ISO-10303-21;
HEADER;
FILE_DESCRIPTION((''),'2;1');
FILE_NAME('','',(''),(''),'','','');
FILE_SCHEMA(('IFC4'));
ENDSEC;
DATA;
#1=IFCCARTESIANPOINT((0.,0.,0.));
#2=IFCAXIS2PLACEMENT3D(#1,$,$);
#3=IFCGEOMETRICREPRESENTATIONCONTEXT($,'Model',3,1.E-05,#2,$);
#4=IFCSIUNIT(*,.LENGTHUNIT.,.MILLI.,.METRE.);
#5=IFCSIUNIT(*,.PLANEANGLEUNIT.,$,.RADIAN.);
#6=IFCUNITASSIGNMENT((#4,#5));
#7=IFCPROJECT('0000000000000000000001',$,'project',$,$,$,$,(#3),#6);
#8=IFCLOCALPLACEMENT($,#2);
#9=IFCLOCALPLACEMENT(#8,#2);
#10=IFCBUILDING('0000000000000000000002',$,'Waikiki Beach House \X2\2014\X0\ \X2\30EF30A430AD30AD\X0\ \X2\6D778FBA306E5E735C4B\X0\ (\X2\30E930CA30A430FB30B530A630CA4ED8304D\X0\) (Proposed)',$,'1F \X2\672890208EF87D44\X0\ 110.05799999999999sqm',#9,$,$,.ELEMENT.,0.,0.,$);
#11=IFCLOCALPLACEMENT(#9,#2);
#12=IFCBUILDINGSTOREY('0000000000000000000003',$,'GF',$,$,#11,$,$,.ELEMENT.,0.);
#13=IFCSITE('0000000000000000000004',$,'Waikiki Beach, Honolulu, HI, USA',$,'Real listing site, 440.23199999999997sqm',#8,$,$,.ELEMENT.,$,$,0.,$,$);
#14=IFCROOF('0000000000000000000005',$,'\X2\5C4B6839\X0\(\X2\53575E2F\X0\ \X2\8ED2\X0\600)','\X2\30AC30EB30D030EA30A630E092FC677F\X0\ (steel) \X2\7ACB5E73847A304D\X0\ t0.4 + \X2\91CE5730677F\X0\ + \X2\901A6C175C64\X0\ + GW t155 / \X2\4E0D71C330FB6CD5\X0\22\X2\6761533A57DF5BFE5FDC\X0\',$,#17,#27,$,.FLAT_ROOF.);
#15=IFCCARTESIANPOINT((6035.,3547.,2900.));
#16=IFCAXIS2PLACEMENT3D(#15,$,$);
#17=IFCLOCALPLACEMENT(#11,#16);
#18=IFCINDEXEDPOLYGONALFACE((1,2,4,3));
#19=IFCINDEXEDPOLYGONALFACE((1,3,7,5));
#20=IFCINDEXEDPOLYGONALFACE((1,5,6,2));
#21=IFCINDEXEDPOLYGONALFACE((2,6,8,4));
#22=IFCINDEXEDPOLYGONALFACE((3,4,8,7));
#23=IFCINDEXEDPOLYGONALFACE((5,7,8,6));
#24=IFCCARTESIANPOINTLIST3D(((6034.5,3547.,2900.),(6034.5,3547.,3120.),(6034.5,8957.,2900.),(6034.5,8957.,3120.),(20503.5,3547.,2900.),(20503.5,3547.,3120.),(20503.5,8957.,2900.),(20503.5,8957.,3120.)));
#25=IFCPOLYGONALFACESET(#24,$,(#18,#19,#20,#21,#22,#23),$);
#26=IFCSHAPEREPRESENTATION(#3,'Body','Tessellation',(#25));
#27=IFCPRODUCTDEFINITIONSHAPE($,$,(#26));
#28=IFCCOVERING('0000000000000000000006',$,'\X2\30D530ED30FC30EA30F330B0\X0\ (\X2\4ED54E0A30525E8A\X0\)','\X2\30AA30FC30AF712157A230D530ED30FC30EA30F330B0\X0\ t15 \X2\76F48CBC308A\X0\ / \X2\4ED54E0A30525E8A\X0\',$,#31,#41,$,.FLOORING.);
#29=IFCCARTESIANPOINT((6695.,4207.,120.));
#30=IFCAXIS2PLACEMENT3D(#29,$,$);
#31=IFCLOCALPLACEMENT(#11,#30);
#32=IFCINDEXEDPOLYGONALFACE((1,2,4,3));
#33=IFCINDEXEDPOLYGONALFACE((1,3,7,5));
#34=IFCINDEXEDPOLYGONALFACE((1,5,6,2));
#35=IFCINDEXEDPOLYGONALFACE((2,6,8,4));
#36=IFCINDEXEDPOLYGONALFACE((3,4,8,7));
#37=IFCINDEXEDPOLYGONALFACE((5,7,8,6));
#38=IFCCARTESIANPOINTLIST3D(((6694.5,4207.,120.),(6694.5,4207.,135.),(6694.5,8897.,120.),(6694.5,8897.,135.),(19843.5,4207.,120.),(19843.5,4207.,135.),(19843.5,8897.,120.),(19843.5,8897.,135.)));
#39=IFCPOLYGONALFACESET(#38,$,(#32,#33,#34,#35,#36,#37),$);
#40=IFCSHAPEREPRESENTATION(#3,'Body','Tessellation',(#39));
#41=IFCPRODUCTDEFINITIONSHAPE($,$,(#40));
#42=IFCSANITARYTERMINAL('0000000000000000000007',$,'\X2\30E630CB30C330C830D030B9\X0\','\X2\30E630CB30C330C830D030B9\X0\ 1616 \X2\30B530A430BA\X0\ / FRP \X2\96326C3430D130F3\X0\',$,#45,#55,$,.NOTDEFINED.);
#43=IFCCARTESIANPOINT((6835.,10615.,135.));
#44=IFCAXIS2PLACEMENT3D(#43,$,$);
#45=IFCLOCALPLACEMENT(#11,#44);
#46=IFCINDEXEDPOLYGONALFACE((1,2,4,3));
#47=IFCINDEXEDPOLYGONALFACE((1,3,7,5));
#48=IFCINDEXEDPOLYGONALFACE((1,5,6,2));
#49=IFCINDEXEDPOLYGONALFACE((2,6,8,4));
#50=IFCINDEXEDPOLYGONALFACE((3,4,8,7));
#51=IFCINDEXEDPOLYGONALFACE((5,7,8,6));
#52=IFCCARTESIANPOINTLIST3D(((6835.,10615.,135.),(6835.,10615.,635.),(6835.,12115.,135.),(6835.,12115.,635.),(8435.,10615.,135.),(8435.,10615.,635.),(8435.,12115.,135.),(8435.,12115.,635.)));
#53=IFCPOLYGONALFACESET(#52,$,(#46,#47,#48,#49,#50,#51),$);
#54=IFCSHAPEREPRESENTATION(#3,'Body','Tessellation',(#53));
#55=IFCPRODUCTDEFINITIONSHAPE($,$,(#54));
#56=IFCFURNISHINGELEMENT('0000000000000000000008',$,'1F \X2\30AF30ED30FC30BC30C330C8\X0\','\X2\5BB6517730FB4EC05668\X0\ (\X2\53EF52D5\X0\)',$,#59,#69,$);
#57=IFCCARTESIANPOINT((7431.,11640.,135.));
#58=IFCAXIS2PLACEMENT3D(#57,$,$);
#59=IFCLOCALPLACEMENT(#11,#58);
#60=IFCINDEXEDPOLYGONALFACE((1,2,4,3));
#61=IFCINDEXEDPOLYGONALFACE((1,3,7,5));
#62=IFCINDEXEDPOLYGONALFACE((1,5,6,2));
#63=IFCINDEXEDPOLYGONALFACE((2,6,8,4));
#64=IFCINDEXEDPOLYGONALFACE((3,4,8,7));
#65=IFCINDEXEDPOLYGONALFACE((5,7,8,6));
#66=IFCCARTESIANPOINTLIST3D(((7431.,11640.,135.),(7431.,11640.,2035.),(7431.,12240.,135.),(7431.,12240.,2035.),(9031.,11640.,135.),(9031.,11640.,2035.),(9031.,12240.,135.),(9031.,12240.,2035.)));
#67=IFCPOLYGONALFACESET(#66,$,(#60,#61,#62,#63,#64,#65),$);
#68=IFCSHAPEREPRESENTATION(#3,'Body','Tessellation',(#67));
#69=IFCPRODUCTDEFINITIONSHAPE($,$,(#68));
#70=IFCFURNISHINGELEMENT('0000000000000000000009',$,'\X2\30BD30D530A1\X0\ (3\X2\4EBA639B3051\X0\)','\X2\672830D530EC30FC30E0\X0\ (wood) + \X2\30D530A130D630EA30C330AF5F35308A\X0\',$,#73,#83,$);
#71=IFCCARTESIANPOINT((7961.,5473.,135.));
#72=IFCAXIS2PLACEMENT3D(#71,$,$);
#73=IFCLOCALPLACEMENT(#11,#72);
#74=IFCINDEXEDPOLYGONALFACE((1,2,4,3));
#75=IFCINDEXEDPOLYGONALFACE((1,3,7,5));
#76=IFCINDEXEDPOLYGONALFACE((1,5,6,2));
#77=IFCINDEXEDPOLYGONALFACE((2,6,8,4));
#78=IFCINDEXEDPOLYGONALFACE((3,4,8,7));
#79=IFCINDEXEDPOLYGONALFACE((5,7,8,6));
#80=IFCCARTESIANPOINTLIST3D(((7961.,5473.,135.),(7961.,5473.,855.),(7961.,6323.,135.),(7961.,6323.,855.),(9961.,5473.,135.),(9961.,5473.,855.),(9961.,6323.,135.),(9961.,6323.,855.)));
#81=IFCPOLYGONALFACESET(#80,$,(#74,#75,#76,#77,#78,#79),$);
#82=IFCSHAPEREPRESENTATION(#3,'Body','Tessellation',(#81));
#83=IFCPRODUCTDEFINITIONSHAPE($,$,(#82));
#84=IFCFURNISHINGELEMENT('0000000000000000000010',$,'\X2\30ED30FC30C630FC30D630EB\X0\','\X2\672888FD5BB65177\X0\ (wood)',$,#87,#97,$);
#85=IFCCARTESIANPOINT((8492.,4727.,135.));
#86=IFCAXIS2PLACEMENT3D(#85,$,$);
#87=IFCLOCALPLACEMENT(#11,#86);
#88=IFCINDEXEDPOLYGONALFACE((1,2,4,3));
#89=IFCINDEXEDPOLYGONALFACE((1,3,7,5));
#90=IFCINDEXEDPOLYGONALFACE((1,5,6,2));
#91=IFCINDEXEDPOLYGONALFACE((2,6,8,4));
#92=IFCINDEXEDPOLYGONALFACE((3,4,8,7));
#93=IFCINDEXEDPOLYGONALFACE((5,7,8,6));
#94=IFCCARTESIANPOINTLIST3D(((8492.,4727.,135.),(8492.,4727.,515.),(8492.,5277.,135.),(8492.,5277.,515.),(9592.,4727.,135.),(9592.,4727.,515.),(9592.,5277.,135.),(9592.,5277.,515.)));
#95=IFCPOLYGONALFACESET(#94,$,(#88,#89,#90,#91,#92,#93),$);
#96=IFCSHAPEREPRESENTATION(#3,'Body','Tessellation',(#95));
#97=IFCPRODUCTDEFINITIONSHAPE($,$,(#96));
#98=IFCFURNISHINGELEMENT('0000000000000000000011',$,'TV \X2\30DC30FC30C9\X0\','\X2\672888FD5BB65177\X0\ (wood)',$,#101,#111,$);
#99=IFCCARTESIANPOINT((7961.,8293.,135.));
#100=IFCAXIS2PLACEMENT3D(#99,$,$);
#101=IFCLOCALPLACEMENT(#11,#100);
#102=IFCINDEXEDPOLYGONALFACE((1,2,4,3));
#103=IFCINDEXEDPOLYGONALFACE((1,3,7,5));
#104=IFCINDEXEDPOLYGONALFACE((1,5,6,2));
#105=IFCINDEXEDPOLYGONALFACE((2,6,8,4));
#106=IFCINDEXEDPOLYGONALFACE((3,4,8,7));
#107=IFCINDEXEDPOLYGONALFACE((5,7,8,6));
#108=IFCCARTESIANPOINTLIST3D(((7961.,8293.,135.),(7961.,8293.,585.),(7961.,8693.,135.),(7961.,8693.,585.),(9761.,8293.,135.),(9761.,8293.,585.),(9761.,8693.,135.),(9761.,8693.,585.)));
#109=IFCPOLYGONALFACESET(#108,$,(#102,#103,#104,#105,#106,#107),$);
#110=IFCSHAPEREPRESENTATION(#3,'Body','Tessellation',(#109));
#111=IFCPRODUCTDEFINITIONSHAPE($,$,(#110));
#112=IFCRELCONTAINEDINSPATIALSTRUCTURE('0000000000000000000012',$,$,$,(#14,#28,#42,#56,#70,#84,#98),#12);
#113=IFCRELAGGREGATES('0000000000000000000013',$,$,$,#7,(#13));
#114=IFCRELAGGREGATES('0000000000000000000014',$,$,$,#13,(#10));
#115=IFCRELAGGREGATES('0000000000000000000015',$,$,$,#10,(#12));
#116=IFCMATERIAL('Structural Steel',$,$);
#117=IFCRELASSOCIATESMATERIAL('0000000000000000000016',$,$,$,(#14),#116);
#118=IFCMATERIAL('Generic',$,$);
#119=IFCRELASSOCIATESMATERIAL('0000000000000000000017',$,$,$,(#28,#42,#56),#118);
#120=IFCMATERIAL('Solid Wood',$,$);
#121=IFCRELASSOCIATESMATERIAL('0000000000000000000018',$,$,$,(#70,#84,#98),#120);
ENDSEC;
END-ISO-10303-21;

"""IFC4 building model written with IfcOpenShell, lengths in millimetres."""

from ifc_helpers import new_model, si_unit, frame, frame_2d, origin, place, context, project, spatial, rectangle, extrude, material, element, save


model = new_model("IFC4")

# Units and contexts
model_context = context("Model", 3, precision=1e-05, world=origin())
ifc_project = project(units=[si_unit("LENGTHUNIT", "METRE", prefix="MILLI"), si_unit("PLANEANGLEUNIT", "RADIAN")], contexts=[model_context])

# Site, building, storey
site_placement = place(None, origin())
site = spatial("IfcSite", under=ifc_project, at=site_placement, Name="Waikiki Beach, Honolulu, HI, USA", ObjectType="Real listing site, 440.23199999999997sqm", CompositionType="ELEMENT", RefElevation=0.0)
building_placement = place(site_placement, origin())
building = spatial("IfcBuilding", under=site, at=building_placement, Name="Waikiki Beach House — ワイキキ 海辺の平屋 (ラナイ・サウナ付き) (Proposed)", ObjectType="1F 木造軸組 110.05799999999999sqm", CompositionType="ELEMENT", ElevationOfRefHeight=0.0, ElevationOfTerrain=0.0)
storey_placement = place(building_placement, origin())
storey = spatial("IfcBuildingStorey", under=building, at=storey_placement, Name="GF", CompositionType="ELEMENT", Elevation=0.0)

# Shared definitions
ifc_material_1 = material(Name="Solid Wood")

# Roof
ifc_material_2 = material(Name="Structural Steel")
roof_1_placement = place(storey_placement, frame((6035.0, 3547.0, 2900.0)))
element("IfcRoof", 1, at=roof_1_placement, inside=storey, material=ifc_material_2, Name="屋根(南帯 軒600)", Description="ガルバリウム鋼板 (steel) 立平葺き t0.4 + 野地板 + 通気層 + GW t155 / 不燃・法22条区域対応", PredefinedType="FLAT_ROOF", context=model_context, shape_type="SweptSolid", body=[
    extrude(rectangle(XDim=14469.0, YDim=5410.0, at=frame_2d((7234.0, 2705.0))), frame((6035.0, 3547.0, 2900.0)), (0.0, 0.0, 1.0), 220.0),
])

# Covering
ifc_material_3 = material(Name="Generic")
covering_1_placement = place(storey_placement, frame((6695.0, 4207.0, 120.0)))
element("IfcCovering", 2, at=covering_1_placement, inside=storey, material=ifc_material_3, Name="フローリング (仕上げ床)", Description="オーク無垢フローリング t15 直貼り / 仕上げ床", PredefinedType="FLOORING", context=model_context, shape_type="SweptSolid", body=[
    extrude(rectangle(XDim=13149.0, YDim=4690.0, at=frame_2d((6574.0, 2345.0))), frame((6695.0, 4207.0, 120.0)), (0.0, 0.0, 1.0), 15.0),
])

# Sanitary terminal
sanitary_terminal_placement = place(storey_placement, frame((6835.0, 10615.0, 135.0)))
element("IfcSanitaryTerminal", 3, at=sanitary_terminal_placement, inside=storey, material=ifc_material_3, Name="ユニットバス", Description="ユニットバス 1616 サイズ / FRP 防水パン", PredefinedType="NOTDEFINED", context=model_context, shape_type="SweptSolid", body=[
    extrude(rectangle(XDim=1600.0, YDim=1500.0, at=frame_2d((800.0, 750.0))), frame((6835.0, 10615.0, 135.0)), (0.0, 0.0, 1.0), 500.0),
])

# Furnishing elements
furnishing_1_placement = place(storey_placement, frame((7431.0, 11640.0, 135.0)))
element("IfcFurnishingElement", 4, at=furnishing_1_placement, inside=storey, material=ifc_material_3, Name="1F クローゼット", Description="家具・什器 (可動)", context=model_context, shape_type="SweptSolid", body=[
    extrude(rectangle(XDim=1600.0, YDim=600.0, at=frame_2d((800.0, 300.0))), frame((7431.0, 11640.0, 135.0)), (0.0, 0.0, 1.0), 1900.0),
])
furnishing_2_placement = place(storey_placement, frame((7961.0, 5473.0, 135.0)))
element("IfcFurnishingElement", 5, at=furnishing_2_placement, inside=storey, material=ifc_material_1, Name="ソファ (3人掛け)", Description="木フレーム (wood) + ファブリック張り", context=model_context, shape_type="SweptSolid", body=[
    extrude(rectangle(XDim=2000.0, YDim=850.0, at=frame_2d((1000.0, 425.0))), frame((7961.0, 5473.0, 135.0)), (0.0, 0.0, 1.0), 720.0),
])
furnishing_3_placement = place(storey_placement, frame((8492.0, 4727.0, 135.0)))
element("IfcFurnishingElement", 6, at=furnishing_3_placement, inside=storey, material=ifc_material_1, Name="ローテーブル", Description="木製家具 (wood)", context=model_context, shape_type="SweptSolid", body=[
    extrude(rectangle(XDim=1100.0, YDim=550.0, at=frame_2d((550.0, 275.0))), frame((8492.0, 4727.0, 135.0)), (0.0, 0.0, 1.0), 380.0),
])
furnishing_4_placement = place(storey_placement, frame((7961.0, 8293.0, 135.0)))
element("IfcFurnishingElement", 7, at=furnishing_4_placement, inside=storey, material=ifc_material_1, Name="TV ボード", Description="木製家具 (wood)", context=model_context, shape_type="SweptSolid", body=[
    extrude(rectangle(XDim=1800.0, YDim=400.0, at=frame_2d((900.0, 200.0))), frame((7961.0, 8293.0, 135.0)), (0.0, 0.0, 1.0), 450.0),
])

save(model, "model.ifc")
